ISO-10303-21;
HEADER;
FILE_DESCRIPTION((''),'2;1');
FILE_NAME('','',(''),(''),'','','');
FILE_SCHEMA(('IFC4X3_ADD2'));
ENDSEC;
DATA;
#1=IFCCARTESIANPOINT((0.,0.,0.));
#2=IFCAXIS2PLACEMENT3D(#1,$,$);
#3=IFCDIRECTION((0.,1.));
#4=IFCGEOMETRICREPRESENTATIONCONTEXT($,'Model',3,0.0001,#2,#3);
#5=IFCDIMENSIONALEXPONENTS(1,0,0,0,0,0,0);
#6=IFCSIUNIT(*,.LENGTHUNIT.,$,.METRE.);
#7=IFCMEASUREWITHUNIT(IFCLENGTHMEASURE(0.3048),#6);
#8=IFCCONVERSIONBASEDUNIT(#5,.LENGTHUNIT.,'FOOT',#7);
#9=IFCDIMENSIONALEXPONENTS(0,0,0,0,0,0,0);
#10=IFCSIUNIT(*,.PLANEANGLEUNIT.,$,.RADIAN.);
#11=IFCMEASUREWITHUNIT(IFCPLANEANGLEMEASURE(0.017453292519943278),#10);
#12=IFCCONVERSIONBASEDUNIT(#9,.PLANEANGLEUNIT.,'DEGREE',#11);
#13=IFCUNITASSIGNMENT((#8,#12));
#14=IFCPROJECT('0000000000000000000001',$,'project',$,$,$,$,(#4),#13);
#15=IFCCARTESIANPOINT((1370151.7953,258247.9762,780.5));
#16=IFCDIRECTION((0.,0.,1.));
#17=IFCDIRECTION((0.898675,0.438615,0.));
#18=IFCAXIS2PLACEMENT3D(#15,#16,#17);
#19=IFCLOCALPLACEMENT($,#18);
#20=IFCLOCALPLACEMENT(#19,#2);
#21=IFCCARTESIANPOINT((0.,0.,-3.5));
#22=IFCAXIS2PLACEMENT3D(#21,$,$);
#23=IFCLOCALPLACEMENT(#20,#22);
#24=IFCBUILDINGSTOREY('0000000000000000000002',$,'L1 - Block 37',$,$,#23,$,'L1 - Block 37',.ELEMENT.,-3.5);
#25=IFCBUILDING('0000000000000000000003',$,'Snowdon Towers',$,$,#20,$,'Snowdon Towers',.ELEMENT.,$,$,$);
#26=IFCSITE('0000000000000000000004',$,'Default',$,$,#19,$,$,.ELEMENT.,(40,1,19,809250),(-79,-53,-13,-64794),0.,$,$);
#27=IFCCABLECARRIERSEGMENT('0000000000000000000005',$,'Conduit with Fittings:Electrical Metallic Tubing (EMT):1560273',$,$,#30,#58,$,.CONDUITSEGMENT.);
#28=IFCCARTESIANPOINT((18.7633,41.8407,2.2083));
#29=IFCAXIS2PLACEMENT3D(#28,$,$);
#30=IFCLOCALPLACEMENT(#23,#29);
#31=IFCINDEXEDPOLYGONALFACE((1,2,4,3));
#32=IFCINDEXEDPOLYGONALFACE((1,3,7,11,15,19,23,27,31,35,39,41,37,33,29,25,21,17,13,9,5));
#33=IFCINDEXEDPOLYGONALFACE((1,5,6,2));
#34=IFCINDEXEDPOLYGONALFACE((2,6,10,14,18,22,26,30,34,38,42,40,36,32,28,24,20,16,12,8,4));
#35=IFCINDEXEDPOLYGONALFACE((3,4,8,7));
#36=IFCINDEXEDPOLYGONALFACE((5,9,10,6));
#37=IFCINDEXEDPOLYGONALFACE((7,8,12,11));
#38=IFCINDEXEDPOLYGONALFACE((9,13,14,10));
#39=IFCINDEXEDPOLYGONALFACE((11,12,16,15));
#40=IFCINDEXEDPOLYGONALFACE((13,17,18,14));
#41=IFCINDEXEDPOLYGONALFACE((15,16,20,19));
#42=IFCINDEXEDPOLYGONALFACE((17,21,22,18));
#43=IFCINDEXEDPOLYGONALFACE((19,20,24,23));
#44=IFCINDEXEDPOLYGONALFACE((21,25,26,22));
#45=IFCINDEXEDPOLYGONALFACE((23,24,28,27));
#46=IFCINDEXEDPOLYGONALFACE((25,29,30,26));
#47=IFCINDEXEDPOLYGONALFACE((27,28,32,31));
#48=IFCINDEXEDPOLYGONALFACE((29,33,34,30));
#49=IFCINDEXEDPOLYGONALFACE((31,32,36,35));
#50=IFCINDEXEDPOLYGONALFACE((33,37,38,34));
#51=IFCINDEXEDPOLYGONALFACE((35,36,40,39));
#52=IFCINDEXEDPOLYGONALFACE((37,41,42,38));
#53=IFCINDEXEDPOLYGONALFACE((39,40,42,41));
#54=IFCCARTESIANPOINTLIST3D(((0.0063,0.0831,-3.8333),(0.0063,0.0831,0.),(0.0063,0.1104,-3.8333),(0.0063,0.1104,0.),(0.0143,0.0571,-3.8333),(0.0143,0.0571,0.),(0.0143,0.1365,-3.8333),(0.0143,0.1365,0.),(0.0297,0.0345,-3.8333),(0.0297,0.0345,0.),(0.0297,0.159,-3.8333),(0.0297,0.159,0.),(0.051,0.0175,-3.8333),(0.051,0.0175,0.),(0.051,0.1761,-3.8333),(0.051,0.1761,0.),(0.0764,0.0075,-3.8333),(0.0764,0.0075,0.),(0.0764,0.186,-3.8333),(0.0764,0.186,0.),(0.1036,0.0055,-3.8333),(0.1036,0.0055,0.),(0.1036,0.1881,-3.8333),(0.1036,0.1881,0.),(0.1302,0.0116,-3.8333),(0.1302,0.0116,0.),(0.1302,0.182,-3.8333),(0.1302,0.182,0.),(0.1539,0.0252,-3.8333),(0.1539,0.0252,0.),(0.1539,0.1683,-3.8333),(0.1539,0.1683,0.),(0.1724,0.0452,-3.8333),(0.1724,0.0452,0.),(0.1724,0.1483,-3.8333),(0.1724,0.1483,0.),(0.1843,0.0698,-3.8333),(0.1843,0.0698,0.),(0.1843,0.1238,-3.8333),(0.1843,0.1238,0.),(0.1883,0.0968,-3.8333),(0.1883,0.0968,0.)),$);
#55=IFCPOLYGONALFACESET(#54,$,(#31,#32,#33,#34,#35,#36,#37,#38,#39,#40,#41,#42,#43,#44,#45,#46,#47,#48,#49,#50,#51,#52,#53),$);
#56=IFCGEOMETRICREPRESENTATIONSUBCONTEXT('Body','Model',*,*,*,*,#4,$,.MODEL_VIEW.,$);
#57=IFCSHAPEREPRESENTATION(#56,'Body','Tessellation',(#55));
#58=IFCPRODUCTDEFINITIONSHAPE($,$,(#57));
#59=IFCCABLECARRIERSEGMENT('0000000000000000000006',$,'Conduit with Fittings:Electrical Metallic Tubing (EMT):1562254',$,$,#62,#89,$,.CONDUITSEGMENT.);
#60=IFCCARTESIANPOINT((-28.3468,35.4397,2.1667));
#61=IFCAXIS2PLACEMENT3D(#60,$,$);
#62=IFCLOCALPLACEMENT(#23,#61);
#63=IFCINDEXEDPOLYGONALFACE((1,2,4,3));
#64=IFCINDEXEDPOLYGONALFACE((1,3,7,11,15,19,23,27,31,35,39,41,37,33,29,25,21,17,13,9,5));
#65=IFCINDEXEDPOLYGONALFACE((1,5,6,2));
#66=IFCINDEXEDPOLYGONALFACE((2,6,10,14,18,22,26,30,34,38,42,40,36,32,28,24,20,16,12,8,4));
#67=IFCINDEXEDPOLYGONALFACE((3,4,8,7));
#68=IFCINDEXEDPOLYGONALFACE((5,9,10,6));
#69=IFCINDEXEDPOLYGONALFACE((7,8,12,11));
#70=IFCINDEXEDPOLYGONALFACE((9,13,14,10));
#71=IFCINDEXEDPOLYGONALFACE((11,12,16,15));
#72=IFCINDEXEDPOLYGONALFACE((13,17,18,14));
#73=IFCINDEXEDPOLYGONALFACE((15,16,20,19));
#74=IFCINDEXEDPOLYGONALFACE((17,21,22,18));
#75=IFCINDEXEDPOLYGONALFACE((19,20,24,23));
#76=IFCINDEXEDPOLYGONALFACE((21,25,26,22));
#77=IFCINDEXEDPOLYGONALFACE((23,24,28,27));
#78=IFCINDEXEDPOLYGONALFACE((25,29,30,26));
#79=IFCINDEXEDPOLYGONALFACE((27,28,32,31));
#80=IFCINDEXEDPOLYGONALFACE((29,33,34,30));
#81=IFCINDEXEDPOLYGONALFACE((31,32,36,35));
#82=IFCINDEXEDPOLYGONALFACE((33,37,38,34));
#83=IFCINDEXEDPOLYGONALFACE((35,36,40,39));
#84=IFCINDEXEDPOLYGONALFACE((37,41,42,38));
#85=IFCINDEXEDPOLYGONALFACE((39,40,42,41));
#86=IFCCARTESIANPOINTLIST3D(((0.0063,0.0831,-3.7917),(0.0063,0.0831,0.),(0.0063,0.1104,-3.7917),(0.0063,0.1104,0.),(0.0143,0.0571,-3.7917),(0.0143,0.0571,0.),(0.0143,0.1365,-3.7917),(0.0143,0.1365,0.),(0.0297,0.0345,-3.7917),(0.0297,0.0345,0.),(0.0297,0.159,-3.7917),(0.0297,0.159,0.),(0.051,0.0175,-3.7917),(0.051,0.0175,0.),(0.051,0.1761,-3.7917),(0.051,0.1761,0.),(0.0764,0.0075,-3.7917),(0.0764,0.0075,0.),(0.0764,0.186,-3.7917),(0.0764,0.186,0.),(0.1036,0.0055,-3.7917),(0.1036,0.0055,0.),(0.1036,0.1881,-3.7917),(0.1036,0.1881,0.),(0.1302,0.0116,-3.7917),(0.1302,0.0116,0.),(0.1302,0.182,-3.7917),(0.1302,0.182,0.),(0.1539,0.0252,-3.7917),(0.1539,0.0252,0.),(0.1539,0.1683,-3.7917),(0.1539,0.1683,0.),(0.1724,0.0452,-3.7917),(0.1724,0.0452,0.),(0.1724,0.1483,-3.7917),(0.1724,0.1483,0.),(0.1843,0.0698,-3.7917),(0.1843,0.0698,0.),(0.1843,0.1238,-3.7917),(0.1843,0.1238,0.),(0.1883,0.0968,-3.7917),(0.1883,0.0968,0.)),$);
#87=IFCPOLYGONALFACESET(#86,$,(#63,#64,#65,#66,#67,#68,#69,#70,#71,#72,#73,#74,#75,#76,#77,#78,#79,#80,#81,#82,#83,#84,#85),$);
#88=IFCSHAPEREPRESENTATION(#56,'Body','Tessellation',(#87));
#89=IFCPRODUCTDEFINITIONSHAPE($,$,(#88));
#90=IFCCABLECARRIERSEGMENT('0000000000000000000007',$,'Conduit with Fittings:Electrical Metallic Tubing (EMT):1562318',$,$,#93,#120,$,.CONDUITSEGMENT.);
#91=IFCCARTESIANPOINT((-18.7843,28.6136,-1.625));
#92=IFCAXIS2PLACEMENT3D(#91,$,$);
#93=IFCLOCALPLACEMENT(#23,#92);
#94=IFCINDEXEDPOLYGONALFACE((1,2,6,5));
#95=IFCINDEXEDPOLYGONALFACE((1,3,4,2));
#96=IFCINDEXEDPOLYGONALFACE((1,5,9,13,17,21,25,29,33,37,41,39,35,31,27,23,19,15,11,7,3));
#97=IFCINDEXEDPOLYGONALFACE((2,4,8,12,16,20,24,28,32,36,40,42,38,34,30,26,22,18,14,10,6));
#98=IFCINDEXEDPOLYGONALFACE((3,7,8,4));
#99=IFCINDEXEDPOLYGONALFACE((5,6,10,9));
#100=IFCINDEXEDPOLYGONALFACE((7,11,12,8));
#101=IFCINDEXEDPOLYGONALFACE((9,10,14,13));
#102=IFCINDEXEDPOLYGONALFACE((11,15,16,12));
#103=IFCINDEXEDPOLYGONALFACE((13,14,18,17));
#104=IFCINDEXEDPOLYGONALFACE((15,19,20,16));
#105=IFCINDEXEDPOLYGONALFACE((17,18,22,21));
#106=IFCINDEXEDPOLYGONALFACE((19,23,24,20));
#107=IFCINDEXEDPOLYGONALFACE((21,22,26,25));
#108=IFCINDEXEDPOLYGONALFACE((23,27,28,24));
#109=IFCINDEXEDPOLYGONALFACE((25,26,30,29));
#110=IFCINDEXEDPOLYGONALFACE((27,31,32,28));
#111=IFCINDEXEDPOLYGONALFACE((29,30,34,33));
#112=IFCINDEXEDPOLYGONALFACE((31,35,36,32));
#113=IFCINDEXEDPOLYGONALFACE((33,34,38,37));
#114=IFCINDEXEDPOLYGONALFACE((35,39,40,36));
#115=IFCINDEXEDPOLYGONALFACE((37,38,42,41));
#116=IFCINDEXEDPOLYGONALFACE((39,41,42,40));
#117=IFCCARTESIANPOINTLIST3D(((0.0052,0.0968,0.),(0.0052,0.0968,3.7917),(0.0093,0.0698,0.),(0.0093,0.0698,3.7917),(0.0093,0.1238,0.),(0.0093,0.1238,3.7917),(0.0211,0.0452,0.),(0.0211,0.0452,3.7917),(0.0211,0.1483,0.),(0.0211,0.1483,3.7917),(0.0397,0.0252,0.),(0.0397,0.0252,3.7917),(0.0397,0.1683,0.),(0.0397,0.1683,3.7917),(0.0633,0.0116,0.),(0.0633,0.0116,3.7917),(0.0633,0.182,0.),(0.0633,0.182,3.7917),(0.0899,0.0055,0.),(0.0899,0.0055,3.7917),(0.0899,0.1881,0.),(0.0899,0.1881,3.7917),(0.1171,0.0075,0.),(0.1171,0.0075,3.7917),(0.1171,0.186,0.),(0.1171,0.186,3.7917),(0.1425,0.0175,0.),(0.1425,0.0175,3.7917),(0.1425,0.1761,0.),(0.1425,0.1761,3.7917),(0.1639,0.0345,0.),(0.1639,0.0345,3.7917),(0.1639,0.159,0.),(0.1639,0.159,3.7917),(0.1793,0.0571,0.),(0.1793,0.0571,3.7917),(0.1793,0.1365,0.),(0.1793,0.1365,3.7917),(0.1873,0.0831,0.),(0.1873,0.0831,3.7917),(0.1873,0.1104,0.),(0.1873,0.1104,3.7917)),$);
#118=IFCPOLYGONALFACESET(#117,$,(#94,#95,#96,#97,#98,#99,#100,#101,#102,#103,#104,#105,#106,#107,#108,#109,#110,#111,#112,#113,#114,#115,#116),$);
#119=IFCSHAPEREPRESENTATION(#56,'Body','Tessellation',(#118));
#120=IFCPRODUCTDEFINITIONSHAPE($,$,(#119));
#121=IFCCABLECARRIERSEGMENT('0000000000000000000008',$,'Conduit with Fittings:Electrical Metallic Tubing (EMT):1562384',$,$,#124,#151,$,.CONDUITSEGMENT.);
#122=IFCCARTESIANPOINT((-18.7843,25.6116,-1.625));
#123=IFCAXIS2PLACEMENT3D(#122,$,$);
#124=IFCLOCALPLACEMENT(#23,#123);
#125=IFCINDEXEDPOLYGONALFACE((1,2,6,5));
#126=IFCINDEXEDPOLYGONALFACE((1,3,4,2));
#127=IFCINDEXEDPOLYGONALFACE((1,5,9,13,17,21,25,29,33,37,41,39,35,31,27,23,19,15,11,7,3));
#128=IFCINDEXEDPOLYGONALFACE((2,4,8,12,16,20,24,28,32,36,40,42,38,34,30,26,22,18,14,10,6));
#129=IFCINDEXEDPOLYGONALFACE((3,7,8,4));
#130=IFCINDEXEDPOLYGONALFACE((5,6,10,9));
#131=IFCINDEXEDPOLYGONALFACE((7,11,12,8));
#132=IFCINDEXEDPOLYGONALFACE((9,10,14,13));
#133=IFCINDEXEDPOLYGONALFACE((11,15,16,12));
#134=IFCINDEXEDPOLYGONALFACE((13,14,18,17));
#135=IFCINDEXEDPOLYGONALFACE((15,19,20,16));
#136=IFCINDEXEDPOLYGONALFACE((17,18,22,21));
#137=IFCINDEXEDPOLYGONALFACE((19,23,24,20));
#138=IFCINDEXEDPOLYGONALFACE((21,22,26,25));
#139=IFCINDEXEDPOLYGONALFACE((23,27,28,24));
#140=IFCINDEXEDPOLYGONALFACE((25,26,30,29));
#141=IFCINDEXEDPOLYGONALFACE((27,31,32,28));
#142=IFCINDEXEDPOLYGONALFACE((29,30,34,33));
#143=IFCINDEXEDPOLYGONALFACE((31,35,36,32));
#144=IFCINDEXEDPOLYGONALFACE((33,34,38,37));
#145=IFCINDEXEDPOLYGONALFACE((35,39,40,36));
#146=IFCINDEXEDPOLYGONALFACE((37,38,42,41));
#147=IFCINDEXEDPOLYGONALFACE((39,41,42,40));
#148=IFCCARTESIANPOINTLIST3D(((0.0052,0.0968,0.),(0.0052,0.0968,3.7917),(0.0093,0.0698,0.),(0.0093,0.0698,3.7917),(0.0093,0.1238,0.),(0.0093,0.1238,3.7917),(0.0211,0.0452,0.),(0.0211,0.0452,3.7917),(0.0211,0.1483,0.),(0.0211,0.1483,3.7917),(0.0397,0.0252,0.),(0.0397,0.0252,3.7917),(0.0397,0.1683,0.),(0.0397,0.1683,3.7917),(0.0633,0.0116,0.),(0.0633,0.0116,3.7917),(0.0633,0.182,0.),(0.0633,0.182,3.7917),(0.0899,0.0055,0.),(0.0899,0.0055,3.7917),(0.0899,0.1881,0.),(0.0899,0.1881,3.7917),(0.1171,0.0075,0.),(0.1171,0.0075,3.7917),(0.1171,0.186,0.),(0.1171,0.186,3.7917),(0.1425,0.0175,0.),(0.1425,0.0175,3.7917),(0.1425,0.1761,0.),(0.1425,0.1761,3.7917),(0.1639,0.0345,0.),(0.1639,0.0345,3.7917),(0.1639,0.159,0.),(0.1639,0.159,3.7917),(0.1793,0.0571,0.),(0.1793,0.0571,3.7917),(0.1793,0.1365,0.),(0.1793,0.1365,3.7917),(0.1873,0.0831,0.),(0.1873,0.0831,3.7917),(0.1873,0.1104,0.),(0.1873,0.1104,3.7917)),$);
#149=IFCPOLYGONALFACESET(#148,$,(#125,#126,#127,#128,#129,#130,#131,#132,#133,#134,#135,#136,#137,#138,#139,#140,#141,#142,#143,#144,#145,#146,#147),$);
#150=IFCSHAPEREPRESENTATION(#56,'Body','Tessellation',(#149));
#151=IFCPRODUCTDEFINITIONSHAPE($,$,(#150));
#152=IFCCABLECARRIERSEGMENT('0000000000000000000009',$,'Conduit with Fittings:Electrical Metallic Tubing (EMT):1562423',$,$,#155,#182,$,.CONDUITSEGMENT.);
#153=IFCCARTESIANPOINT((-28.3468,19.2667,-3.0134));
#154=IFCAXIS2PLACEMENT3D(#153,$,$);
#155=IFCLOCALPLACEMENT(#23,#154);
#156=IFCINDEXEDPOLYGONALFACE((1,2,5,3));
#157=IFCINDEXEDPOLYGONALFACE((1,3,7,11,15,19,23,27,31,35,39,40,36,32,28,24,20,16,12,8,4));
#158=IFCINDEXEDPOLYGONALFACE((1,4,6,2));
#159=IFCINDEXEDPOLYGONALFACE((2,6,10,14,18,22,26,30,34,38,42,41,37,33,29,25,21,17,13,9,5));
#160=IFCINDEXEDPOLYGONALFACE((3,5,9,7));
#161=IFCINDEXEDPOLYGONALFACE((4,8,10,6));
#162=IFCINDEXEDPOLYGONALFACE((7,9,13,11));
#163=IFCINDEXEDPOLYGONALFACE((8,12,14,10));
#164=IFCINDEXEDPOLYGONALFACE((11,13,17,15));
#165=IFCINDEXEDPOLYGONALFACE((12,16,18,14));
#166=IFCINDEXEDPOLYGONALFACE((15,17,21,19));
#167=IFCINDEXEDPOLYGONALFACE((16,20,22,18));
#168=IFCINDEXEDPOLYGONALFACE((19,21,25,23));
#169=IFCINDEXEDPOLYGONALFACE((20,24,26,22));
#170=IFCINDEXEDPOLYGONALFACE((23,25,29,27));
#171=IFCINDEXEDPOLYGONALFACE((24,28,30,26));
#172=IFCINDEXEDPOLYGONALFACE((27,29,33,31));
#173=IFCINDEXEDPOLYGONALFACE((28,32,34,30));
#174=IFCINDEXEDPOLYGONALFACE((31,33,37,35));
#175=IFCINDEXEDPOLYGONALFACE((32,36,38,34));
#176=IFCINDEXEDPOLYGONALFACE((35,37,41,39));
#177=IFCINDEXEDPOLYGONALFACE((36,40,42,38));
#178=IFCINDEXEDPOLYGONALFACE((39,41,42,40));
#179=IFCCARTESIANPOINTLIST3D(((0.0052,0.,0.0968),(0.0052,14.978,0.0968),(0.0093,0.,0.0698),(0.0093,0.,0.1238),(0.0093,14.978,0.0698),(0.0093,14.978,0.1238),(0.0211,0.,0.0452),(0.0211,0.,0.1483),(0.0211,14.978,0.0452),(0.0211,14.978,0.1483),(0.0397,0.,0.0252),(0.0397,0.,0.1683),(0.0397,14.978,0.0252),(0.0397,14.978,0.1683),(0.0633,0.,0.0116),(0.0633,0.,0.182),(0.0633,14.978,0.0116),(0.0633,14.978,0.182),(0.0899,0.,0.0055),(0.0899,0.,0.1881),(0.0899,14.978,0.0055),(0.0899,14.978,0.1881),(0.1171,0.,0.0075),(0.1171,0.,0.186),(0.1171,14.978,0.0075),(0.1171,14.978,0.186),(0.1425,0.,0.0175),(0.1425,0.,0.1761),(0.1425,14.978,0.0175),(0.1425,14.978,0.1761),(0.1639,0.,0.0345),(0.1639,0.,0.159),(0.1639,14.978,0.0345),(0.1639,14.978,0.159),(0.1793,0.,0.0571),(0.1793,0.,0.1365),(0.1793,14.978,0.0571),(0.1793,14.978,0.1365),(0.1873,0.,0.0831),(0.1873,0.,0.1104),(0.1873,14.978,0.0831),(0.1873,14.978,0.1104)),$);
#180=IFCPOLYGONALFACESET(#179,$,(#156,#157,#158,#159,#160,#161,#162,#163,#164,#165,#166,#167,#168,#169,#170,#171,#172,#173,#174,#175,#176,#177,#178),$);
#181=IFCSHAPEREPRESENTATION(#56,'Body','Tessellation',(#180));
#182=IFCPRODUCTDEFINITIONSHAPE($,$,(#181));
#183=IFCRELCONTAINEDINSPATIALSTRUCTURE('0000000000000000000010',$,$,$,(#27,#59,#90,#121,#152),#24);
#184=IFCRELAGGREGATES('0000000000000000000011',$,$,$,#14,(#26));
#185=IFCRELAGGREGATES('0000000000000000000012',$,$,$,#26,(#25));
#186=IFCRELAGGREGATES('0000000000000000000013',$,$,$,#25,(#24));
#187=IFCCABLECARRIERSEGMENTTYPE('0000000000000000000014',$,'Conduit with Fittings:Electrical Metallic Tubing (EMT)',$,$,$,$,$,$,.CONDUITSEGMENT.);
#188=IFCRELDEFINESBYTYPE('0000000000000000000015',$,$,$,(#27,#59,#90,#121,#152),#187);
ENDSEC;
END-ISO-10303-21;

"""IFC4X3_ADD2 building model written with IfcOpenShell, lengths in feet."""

from ifc_helpers import new_model, entity, si_unit, converted_unit, direction, frame, frame_2d, origin, place, context, subcontext, project, spatial, circle, extrude, type_object, element, save


model = new_model("IFC4X3_ADD2")

# Units and contexts
model_context = context("Model", 3, precision=0.0001, world=origin(), true_north=direction((0.0, 1.0)))
body_context = subcontext(model_context, "Body", "Model", "MODEL_VIEW")
ifc_project = project(units=[converted_unit("LENGTHUNIT", "FOOT", entity("IfcLengthMeasure", 0.3048), si_unit("LENGTHUNIT", "METRE"), dimensions=[1, 0, 0, 0, 0, 0, 0]), converted_unit("PLANEANGLEUNIT", "DEGREE", entity("IfcPlaneAngleMeasure", 0.017453292519943278), si_unit("PLANEANGLEUNIT", "RADIAN"), dimensions=[0, 0, 0, 0, 0, 0, 0])], contexts=[model_context])

# Site, building, storey
site_placement = place(None, frame((1370151.7953, 258247.9762, 780.5), z_axis=(0.0, 0.0, 1.0), x_axis=(0.898675, 0.438615, 0.0)))
site = spatial("IfcSite", under=ifc_project, at=site_placement, Name="Default", CompositionType="ELEMENT", RefLatitude=(40, 1, 19, 809250), RefLongitude=(-79, -53, -13, -64794), RefElevation=0.0)
building_placement = place(site_placement, origin())
building = spatial("IfcBuilding", under=site, at=building_placement, Name="Snowdon Towers", LongName="Snowdon Towers", CompositionType="ELEMENT")
storey_placement = place(building_placement, frame((0.0, 0.0, -3.5)))
storey = spatial("IfcBuildingStorey", under=building, at=storey_placement, Name="L1 - Block 37", LongName="L1 - Block 37", CompositionType="ELEMENT", Elevation=-3.5)

# Cable carrier segments
cable_carrier_segment_type = type_object("IfcCableCarrierSegmentType", Name="Conduit with Fittings:Electrical Metallic Tubing (EMT)", PredefinedType="CONDUITSEGMENT")
cable_carrier_segment_1_placement = place(storey_placement, frame((18.7633, 41.8407, 2.2083)))
element("IfcCableCarrierSegment", 1, at=cable_carrier_segment_1_placement, inside=storey, type_object=cable_carrier_segment_type, Name="Conduit with Fittings:Electrical Metallic Tubing (EMT):1560273", PredefinedType="CONDUITSEGMENT", context=body_context, shape_type="SweptSolid", body=[
    extrude(circle(Radius=0.0915, at=frame_2d((0.0, 0.0), x_axis=(1.0, 0.0))), frame((0.0968, 0.0968, -3.8333)), (0.0, 0.0, 1.0), 3.8333),
])
cable_carrier_segment_2_placement = place(storey_placement, frame((-28.3468, 35.4397, 2.1667)))
element("IfcCableCarrierSegment", 2, at=cable_carrier_segment_2_placement, inside=storey, type_object=cable_carrier_segment_type, Name="Conduit with Fittings:Electrical Metallic Tubing (EMT):1562254", PredefinedType="CONDUITSEGMENT", context=body_context, shape_type="SweptSolid", body=[
    extrude(circle(Radius=0.0915, at=frame_2d((0.0, 0.0), x_axis=(1.0, 0.0))), frame((0.0968, 0.0968, -3.7917)), (0.0, 0.0, 1.0), 3.7917),
])
cable_carrier_segment_3_placement = place(storey_placement, frame((-18.7843, 28.6136, -1.625)))
element("IfcCableCarrierSegment", 3, at=cable_carrier_segment_3_placement, inside=storey, type_object=cable_carrier_segment_type, Name="Conduit with Fittings:Electrical Metallic Tubing (EMT):1562318", PredefinedType="CONDUITSEGMENT", context=body_context, shape_type="SweptSolid", body=[
    extrude(circle(Radius=0.0915, at=frame_2d((0.0, 0.0), x_axis=(1.0, 0.0))), frame((0.0968, 0.0968, 0.0), z_axis=(0.0, 0.0, 1.0), x_axis=(-1.0, 0.0, 0.0)), (0.0, 0.0, 1.0), 3.7917),
])
cable_carrier_segment_4_placement = place(storey_placement, frame((-18.7843, 25.6116, -1.625)))
element("IfcCableCarrierSegment", 4, at=cable_carrier_segment_4_placement, inside=storey, type_object=cable_carrier_segment_type, Name="Conduit with Fittings:Electrical Metallic Tubing (EMT):1562384", PredefinedType="CONDUITSEGMENT", context=body_context, shape_type="SweptSolid", body=[
    extrude(circle(Radius=0.0915, at=frame_2d((0.0, 0.0), x_axis=(1.0, 0.0))), frame((0.0968, 0.0968, 0.0), z_axis=(0.0, 0.0, 1.0), x_axis=(-1.0, 0.0, 0.0)), (0.0, 0.0, 1.0), 3.7917),
])
cable_carrier_segment_5_placement = place(storey_placement, frame((-28.3468, 19.2667, -3.0134)))
element("IfcCableCarrierSegment", 5, at=cable_carrier_segment_5_placement, inside=storey, type_object=cable_carrier_segment_type, Name="Conduit with Fittings:Electrical Metallic Tubing (EMT):1562423", PredefinedType="CONDUITSEGMENT", context=body_context, shape_type="SweptSolid", body=[
    extrude(circle(Radius=0.0915, at=frame_2d((0.0, 0.0), x_axis=(1.0, 0.0))), frame((0.0968, 0.0, 0.0968), z_axis=(0.0, 1.0, 0.0), x_axis=(-1.0, 0.0, 0.0)), (0.0, 0.0, 1.0), 14.978),
])

save(model, "model.ifc")
